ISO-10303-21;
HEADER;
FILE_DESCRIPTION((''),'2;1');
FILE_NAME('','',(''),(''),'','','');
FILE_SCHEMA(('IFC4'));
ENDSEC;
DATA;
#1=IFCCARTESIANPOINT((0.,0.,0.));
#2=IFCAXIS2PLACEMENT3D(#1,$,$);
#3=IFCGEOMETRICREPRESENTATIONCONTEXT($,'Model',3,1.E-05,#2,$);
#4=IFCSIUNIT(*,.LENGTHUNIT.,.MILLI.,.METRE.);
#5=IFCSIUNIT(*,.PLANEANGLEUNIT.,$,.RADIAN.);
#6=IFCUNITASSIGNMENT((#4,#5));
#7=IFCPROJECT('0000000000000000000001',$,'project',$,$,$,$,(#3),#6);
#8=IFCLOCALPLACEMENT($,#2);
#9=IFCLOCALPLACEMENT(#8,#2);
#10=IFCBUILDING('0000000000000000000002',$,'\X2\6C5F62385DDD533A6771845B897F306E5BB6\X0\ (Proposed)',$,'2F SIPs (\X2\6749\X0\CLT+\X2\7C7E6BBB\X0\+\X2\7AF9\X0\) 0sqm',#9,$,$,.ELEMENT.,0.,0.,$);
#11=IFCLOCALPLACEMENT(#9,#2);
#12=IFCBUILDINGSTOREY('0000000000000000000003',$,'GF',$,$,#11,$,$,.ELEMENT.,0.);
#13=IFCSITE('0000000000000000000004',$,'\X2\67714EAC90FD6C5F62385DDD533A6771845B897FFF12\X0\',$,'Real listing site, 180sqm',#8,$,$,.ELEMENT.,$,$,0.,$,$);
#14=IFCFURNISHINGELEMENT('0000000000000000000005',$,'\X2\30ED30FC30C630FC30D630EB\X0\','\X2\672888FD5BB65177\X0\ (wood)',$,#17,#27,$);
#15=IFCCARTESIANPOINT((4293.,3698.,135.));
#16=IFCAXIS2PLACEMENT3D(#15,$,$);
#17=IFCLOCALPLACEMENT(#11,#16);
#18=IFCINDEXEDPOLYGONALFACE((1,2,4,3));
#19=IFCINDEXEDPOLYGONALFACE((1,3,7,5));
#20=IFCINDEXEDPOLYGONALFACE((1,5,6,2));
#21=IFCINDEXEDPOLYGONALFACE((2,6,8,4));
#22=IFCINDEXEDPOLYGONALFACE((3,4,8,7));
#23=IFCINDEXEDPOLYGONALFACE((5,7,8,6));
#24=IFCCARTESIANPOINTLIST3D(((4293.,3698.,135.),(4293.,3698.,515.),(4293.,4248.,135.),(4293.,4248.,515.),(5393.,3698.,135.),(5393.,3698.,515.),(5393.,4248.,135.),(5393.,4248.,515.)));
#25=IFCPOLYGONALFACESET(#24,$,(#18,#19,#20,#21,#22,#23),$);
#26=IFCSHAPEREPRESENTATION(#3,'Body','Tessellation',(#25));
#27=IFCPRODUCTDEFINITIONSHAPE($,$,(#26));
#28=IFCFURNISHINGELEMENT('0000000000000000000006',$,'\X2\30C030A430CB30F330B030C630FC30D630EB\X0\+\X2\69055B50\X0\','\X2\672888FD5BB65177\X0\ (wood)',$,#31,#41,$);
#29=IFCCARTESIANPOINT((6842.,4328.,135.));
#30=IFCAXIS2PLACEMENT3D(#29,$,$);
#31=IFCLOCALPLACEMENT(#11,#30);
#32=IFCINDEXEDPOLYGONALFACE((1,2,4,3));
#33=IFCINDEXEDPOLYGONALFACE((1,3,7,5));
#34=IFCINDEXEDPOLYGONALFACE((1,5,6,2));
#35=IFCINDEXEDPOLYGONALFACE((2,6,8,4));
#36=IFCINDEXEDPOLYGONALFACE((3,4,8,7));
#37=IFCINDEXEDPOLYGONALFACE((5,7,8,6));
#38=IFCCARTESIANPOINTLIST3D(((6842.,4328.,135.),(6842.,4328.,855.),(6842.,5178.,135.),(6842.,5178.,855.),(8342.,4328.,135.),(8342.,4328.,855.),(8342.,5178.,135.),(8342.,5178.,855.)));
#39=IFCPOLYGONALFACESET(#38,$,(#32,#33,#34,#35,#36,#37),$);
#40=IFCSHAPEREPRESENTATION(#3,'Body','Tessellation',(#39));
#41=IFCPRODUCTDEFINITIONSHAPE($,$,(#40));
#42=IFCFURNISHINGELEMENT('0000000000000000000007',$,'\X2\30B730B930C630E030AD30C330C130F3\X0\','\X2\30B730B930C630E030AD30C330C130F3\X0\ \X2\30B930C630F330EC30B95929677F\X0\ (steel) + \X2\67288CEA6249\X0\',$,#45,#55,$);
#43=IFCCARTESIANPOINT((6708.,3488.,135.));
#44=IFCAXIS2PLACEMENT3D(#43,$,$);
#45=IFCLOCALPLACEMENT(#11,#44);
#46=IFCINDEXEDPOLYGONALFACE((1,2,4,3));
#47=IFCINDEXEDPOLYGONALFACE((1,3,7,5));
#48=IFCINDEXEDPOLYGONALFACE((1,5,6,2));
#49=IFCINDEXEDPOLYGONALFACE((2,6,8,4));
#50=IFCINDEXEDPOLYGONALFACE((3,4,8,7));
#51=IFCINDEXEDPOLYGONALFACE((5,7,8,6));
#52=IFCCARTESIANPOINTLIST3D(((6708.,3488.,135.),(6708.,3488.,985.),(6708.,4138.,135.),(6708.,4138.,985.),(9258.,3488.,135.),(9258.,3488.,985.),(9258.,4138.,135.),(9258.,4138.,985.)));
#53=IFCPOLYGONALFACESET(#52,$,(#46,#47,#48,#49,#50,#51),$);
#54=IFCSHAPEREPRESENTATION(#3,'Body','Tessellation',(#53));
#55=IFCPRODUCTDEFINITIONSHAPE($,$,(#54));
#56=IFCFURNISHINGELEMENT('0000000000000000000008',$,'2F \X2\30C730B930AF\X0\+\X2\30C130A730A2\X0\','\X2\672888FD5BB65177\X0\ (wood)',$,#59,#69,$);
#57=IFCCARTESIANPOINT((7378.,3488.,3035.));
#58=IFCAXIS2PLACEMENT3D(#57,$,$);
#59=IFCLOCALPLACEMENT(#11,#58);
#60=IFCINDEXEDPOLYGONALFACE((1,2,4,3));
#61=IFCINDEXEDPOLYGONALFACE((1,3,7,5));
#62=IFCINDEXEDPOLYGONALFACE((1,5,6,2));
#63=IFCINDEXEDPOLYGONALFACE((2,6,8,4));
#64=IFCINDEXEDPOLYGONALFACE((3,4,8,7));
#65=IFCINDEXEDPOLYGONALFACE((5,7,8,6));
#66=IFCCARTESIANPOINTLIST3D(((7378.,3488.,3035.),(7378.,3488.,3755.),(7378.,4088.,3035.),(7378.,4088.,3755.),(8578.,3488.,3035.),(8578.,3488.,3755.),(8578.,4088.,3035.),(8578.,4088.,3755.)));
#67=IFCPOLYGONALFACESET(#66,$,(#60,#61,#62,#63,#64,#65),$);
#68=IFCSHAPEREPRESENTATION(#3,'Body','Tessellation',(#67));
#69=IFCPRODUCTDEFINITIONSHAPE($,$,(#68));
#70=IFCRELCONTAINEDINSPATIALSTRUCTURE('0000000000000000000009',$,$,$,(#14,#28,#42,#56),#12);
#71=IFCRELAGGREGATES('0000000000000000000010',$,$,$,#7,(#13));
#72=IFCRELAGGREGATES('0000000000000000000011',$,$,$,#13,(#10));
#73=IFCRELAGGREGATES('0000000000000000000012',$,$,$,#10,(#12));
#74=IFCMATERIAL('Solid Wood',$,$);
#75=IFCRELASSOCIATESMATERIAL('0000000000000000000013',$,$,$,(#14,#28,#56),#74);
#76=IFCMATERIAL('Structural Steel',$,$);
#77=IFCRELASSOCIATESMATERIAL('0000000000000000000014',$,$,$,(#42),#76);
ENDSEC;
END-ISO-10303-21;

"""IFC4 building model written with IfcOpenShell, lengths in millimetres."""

from ifc_helpers import new_model, si_unit, frame, frame_2d, origin, place, context, project, spatial, rectangle, extrude, material, element, save


model = new_model("IFC4")

# Units and contexts
model_context = context("Model", 3, precision=1e-05, world=origin())
ifc_project = project(units=[si_unit("LENGTHUNIT", "METRE", prefix="MILLI"), si_unit("PLANEANGLEUNIT", "RADIAN")], contexts=[model_context])

# Site, building, storey
site_placement = place(None, origin())
site = spatial("IfcSite", under=ifc_project, at=site_placement, Name="東京都江戸川区東葛西２", ObjectType="Real listing site, 180sqm", CompositionType="ELEMENT", RefElevation=0.0)
building_placement = place(site_placement, origin())
building = spatial("IfcBuilding", under=site, at=building_placement, Name="江戸川区東葛西の家 (Proposed)", ObjectType="2F SIPs (杉CLT+籾殻+竹) 0sqm", CompositionType="ELEMENT", ElevationOfRefHeight=0.0, ElevationOfTerrain=0.0)
storey_placement = place(building_placement, origin())
storey = spatial("IfcBuildingStorey", under=building, at=storey_placement, Name="GF", CompositionType="ELEMENT", Elevation=0.0)

# Shared definitions
ifc_material_1 = material(Name="Solid Wood")

# Shared definitions
ifc_material_2 = material(Name="Structural Steel")

# Furnishing elements
furnishing_1_placement = place(storey_placement, frame((4293.0, 3698.0, 135.0)))
element("IfcFurnishingElement", 1, at=furnishing_1_placement, inside=storey, material=ifc_material_1, Name="ローテーブル", Description="木製家具 (wood)", context=model_context, shape_type="SweptSolid", body=[
    extrude(rectangle(XDim=1100.0, YDim=550.0, at=frame_2d((550.0, 275.0))), frame((4293.0, 3698.0, 135.0)), (0.0, 0.0, 1.0), 380.0),
])
furnishing_2_placement = place(storey_placement, frame((6842.0, 4328.0, 135.0)))
element("IfcFurnishingElement", 2, at=furnishing_2_placement, inside=storey, material=ifc_material_1, Name="ダイニングテーブル+椅子", Description="木製家具 (wood)", context=model_context, shape_type="SweptSolid", body=[
    extrude(rectangle(XDim=1500.0, YDim=850.0, at=frame_2d((750.0, 425.0))), frame((6842.0, 4328.0, 135.0)), (0.0, 0.0, 1.0), 720.0),
])
furnishing_3_placement = place(storey_placement, frame((6708.0, 3488.0, 135.0)))
element("IfcFurnishingElement", 3, at=furnishing_3_placement, inside=storey, material=ifc_material_2, Name="システムキッチン", Description="システムキッチン ステンレス天板 (steel) + 木質扉", context=model_context, shape_type="SweptSolid", body=[
    extrude(rectangle(XDim=2550.0, YDim=650.0, at=frame_2d((1275.0, 325.0))), frame((6708.0, 3488.0, 135.0)), (0.0, 0.0, 1.0), 850.0),
])
furnishing_4_placement = place(storey_placement, frame((7378.0, 3488.0, 3035.0)))
element("IfcFurnishingElement", 4, at=furnishing_4_placement, inside=storey, material=ifc_material_1, Name="2F デスク+チェア", Description="木製家具 (wood)", context=model_context, shape_type="SweptSolid", body=[
    extrude(rectangle(XDim=1200.0, YDim=600.0, at=frame_2d((600.0, 300.0))), frame((7378.0, 3488.0, 3035.0)), (0.0, 0.0, 1.0), 720.0),
])

save(model, "model.ifc")
